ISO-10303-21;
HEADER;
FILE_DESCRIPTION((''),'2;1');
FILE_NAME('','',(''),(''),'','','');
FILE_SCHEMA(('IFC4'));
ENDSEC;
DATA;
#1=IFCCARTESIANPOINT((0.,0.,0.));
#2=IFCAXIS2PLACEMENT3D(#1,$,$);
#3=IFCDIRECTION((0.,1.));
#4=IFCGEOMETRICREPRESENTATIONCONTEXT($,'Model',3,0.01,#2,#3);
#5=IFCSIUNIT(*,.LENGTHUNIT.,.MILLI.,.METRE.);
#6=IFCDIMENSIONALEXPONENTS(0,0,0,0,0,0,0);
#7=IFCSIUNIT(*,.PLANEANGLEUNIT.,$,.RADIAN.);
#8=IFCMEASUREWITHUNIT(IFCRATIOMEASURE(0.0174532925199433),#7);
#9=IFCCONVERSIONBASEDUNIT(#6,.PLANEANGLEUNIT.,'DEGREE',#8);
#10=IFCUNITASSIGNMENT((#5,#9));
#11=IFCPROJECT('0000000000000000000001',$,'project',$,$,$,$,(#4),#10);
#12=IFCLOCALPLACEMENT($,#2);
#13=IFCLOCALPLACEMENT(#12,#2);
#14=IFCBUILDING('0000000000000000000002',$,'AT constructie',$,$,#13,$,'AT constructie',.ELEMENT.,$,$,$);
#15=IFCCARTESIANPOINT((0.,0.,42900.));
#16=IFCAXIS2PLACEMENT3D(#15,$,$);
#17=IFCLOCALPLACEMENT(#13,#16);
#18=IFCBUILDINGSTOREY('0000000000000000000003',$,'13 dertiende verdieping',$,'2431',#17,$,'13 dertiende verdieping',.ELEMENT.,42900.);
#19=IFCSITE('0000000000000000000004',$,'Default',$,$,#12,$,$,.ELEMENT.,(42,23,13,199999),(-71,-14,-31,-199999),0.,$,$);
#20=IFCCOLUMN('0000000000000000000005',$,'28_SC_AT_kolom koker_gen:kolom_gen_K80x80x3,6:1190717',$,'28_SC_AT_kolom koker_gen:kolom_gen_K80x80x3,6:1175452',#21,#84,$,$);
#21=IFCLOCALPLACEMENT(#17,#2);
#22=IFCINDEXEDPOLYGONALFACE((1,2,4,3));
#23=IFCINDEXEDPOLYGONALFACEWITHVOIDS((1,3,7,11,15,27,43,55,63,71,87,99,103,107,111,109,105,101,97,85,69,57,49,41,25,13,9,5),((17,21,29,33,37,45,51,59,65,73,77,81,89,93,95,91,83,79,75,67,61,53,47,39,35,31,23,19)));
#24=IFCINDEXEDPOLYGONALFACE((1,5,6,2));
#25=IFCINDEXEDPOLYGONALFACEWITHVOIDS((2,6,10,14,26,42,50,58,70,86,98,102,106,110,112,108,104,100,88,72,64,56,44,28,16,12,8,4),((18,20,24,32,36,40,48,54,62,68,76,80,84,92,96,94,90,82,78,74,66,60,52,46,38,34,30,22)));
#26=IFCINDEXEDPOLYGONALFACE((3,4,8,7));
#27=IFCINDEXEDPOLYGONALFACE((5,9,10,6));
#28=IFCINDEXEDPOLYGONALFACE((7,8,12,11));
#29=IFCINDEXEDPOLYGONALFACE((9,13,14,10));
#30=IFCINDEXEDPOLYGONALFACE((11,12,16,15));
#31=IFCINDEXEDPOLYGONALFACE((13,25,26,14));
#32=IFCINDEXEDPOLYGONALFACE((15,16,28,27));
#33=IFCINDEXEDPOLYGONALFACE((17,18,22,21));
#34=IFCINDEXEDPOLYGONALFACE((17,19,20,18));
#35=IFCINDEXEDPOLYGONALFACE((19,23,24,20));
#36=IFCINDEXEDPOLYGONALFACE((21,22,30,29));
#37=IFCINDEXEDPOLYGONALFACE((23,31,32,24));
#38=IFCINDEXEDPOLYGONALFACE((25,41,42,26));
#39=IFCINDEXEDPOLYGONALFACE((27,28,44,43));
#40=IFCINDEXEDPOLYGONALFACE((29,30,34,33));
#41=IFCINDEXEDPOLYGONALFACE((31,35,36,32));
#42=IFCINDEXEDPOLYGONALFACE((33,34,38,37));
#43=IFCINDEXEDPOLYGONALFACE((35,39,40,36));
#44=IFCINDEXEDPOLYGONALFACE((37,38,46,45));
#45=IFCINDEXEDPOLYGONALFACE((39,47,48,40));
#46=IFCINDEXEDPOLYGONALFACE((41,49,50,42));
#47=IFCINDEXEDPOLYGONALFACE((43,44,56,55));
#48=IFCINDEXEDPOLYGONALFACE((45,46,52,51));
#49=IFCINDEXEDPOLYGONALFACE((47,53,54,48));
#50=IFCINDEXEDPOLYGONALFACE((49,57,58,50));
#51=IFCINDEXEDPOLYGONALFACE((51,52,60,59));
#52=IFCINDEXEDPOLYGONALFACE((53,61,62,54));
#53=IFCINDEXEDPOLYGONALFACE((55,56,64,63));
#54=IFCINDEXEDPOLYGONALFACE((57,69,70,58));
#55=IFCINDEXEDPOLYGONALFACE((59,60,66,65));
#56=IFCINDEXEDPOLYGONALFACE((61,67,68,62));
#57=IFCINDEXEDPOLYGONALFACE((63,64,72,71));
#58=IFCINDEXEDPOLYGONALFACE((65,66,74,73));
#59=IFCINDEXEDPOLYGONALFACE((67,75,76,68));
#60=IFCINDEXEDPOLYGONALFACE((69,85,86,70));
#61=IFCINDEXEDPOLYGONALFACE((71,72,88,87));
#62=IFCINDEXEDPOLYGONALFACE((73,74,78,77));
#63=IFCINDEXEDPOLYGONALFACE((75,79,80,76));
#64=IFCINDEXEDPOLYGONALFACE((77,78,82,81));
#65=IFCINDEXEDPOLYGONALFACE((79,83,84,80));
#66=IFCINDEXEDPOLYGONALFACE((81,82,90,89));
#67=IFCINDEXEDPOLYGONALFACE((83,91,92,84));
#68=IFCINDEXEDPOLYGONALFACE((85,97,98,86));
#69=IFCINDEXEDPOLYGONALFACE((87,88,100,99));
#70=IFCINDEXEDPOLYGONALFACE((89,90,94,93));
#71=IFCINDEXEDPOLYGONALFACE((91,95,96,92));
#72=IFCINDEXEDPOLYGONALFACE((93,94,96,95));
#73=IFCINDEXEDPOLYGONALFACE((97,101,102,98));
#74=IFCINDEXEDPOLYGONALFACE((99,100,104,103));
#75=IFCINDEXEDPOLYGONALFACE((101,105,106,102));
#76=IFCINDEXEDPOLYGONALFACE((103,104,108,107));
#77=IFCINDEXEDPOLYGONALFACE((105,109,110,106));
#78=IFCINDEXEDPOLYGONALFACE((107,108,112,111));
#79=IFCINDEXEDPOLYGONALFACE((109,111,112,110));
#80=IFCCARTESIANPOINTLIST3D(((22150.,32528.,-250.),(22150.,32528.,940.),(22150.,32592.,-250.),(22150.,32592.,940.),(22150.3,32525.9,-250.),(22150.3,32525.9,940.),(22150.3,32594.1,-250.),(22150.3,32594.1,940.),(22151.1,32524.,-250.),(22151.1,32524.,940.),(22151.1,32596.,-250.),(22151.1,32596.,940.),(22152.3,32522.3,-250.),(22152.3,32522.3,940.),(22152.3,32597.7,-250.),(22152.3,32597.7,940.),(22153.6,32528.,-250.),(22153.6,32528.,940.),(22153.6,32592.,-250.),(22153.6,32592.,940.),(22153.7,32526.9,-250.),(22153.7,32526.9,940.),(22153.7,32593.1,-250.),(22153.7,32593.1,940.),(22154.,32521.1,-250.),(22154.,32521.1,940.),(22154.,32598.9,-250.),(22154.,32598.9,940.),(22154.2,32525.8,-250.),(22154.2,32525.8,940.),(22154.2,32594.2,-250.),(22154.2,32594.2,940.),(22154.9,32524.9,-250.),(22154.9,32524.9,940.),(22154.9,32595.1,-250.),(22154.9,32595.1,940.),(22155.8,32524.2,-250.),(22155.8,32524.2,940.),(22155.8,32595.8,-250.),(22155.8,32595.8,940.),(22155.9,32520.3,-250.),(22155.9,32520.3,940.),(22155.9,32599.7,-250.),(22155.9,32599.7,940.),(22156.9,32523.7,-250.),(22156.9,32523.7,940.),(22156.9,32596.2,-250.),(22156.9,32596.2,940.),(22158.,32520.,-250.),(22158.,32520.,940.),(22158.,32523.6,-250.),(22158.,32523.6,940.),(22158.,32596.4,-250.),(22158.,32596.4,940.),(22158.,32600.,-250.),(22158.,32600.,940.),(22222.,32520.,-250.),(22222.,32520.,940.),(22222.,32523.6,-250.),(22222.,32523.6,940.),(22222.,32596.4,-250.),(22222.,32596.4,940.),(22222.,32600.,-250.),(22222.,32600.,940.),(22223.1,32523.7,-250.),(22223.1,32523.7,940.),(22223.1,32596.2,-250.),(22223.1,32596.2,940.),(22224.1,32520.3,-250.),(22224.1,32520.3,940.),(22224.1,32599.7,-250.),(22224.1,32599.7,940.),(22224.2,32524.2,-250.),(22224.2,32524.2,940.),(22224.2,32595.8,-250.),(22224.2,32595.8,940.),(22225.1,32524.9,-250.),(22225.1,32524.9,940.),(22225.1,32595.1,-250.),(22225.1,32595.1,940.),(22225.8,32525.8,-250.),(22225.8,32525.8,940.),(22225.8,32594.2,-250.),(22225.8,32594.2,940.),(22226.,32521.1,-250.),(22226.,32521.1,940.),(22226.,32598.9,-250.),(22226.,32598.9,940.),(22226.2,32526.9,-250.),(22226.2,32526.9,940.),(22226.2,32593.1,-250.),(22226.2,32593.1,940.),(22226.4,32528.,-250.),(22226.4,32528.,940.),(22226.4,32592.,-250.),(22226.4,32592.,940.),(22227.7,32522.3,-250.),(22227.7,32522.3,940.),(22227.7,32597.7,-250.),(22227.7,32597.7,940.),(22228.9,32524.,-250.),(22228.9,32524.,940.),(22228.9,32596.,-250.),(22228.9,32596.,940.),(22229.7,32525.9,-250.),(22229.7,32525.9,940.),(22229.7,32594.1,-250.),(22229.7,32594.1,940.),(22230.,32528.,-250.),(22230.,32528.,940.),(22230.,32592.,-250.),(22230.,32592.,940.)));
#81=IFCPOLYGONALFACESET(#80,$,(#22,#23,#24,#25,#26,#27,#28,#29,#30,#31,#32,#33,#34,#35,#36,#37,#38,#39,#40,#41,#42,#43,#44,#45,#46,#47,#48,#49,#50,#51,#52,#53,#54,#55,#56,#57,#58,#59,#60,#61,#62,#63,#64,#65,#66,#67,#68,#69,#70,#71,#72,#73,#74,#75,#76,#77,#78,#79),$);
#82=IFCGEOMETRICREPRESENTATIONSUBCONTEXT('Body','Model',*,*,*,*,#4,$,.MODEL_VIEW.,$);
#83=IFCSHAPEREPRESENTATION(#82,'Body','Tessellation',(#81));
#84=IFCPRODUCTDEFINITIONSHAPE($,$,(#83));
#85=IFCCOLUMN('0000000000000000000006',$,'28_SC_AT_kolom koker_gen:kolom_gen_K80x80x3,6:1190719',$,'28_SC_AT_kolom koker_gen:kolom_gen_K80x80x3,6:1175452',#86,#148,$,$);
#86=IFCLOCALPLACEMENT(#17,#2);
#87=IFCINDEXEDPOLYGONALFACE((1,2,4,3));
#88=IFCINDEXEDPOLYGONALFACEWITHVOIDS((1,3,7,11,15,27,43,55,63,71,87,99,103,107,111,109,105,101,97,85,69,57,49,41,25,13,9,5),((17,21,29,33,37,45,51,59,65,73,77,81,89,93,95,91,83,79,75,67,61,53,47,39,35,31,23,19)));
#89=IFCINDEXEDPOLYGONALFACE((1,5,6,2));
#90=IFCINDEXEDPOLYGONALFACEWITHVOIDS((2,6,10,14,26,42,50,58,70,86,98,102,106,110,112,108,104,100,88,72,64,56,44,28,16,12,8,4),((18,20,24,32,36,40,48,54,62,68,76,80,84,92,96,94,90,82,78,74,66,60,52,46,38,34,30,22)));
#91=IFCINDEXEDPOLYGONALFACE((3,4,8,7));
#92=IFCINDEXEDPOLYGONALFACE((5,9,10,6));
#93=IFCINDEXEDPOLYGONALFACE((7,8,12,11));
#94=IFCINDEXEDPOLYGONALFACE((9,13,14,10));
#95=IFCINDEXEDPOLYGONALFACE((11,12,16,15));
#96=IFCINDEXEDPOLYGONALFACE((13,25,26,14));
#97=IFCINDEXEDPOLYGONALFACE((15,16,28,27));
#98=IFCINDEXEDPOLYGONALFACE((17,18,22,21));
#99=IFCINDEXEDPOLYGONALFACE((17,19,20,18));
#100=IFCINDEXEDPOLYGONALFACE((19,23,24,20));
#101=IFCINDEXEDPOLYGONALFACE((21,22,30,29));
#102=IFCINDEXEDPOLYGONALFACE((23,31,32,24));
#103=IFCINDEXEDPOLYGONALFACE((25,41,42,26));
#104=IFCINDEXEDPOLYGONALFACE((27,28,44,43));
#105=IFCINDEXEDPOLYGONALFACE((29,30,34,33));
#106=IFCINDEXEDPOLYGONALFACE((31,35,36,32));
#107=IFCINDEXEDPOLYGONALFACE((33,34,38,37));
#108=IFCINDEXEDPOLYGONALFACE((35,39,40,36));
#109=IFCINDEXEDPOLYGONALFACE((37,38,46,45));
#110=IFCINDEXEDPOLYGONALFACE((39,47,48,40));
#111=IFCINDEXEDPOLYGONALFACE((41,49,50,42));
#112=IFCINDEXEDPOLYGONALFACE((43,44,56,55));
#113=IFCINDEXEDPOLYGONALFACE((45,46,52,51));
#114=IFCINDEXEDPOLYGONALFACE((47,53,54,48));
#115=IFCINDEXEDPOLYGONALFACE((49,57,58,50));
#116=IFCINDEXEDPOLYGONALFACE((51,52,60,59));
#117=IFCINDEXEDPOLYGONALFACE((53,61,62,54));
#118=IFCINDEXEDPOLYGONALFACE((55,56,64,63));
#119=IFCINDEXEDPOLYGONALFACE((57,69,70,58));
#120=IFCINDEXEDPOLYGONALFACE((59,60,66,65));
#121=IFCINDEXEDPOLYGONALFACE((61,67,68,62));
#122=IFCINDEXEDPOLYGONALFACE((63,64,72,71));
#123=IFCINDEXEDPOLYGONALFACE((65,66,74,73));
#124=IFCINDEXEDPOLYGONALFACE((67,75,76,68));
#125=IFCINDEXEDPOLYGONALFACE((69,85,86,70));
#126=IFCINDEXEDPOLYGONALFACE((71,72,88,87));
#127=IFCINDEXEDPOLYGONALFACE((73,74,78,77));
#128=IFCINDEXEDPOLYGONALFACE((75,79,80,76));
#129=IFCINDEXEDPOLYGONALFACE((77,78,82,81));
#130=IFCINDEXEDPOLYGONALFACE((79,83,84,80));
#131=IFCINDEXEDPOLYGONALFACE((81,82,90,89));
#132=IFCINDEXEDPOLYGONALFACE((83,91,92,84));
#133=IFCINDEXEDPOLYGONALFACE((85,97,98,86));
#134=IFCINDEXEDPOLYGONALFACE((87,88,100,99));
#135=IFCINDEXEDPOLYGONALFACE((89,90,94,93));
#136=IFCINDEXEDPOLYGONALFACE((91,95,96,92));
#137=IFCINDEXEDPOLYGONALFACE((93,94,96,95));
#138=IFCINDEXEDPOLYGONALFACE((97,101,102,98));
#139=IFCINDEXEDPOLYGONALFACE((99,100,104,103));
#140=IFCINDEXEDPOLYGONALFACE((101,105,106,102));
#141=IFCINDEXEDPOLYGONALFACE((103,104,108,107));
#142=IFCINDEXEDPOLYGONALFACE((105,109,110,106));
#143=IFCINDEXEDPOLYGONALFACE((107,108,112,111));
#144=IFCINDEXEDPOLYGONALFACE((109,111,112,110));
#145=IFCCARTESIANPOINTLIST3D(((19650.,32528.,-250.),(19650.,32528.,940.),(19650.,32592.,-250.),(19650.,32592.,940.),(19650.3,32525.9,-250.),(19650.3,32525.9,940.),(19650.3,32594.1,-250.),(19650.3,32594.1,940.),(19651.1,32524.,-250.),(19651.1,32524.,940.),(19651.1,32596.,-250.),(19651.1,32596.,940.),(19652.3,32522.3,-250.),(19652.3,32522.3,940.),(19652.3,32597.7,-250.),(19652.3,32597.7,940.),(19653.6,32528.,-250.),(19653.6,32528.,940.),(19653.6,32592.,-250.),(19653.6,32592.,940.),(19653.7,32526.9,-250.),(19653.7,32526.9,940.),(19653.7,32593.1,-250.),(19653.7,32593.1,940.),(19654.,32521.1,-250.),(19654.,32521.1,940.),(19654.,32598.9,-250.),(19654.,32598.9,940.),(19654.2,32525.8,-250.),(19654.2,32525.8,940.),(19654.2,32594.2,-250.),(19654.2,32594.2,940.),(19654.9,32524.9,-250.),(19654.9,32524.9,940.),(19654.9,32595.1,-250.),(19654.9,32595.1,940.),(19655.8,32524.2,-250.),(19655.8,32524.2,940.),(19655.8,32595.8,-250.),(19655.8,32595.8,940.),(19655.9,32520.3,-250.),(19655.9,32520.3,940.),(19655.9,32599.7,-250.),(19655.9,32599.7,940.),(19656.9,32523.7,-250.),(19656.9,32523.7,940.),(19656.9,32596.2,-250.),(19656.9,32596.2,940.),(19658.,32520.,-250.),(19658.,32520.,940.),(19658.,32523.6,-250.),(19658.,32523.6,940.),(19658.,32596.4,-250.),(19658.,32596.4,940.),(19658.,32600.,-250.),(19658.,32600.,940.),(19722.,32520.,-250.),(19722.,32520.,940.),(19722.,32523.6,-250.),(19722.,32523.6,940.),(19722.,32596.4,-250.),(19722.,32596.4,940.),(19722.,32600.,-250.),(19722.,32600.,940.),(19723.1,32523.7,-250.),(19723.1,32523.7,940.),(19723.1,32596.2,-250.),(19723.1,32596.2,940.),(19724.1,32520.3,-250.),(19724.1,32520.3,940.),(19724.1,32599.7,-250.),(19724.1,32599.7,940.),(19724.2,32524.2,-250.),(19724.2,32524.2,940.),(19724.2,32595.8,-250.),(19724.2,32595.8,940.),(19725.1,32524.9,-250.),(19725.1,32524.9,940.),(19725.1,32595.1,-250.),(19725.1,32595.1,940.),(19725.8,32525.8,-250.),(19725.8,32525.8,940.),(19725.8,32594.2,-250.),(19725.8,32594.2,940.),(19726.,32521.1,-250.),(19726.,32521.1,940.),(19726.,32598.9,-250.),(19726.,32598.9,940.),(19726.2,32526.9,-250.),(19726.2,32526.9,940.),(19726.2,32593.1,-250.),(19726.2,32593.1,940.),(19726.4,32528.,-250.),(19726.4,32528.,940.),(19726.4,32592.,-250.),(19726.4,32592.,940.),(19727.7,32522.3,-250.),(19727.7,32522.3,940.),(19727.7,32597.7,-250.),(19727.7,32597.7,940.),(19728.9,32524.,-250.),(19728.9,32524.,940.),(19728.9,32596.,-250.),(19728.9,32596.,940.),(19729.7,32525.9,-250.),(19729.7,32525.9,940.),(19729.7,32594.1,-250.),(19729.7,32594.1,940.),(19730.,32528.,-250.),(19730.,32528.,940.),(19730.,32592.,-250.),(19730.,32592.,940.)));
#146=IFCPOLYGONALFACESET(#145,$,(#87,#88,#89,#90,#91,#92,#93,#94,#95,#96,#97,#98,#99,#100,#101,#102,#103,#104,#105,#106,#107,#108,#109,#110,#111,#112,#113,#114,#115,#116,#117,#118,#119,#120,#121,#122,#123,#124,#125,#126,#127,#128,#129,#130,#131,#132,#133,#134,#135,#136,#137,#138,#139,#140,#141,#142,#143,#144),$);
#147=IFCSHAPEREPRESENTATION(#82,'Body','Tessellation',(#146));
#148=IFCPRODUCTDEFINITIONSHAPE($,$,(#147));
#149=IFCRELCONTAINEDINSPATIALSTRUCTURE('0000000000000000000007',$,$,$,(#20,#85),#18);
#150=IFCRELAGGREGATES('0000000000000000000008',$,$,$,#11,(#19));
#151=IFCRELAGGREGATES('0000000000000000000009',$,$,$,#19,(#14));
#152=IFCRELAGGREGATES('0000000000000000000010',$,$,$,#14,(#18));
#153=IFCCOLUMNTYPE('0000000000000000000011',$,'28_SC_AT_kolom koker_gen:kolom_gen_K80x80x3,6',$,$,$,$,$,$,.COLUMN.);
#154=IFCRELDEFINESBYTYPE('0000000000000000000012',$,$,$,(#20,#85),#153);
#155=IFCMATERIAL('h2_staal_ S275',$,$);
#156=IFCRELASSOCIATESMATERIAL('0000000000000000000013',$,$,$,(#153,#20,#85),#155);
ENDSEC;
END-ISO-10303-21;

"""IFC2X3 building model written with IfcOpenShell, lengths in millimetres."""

from ifc_helpers import new_model, entity, si_unit, converted_unit, direction, frame, frame_2d, origin, place, context, subcontext, project, spatial, polyline, circle_curve, parameter, trimmed, segment, composite_curve, outline, extrude, source, transform, mapped, material, type_object, type_shapes, element, save


model = new_model("IFC2X3")

# Units and contexts
model_context = context("Model", 3, precision=0.01, world=origin(), true_north=direction((0.0, 1.0)))
body_context = subcontext(model_context, "Body", "Model", "MODEL_VIEW")
ifc_project = project(units=[si_unit("LENGTHUNIT", "METRE", prefix="MILLI"), converted_unit("PLANEANGLEUNIT", "DEGREE", entity("IfcRatioMeasure", 0.0174532925199433), si_unit("PLANEANGLEUNIT", "RADIAN"), dimensions=[0, 0, 0, 0, 0, 0, 0])], contexts=[model_context])

# Site, building, storey
site_placement = place(None, origin())
site = spatial("IfcSite", under=ifc_project, at=site_placement, Name="Default", CompositionType="ELEMENT", RefLatitude=(42, 23, 13, 199999), RefLongitude=(-71, -14, -31, -199999), RefElevation=0.0)
building_placement = place(site_placement, origin())
building = spatial("IfcBuilding", under=site, at=building_placement, Name="AT constructie", LongName="AT constructie", CompositionType="ELEMENT")
storey_placement = place(building_placement, frame((0.0, 0.0, 42900.0)))
storey = spatial("IfcBuildingStorey", under=building, at=storey_placement, Name="13 dertiende verdieping", ObjectType="2431", LongName="13 dertiende verdieping", CompositionType="ELEMENT", Elevation=42900.0)

# Columns
ifc_material = material(Name="h2_staal_ S275")
column_type_1 = type_object("IfcColumnType", Name="28_SC_AT_kolom koker_gen:kolom_gen_K80x80x3,6", PredefinedType="COLUMN", material=ifc_material)
shared_shape_1 = source(origin(), body_context, "Body", "SweptSolid", [
    extrude(outline(composite_curve([segment(trimmed(circle_curve(frame_2d((32.0, 32.0), x_axis=(1.0, 0.0)), 8.0), [parameter(360.0)], [parameter(90.0)], True, "PARAMETER"), True, "CONTINUOUS"), segment(polyline([(32.0, 40.0), (-32.0, 40.0)]), True, "CONTINUOUS"), segment(trimmed(circle_curve(frame_2d((-32.0, 32.0), x_axis=(1.0, 0.0)), 8.0), [parameter(90.0)], [parameter(180.0)], True, "PARAMETER"), True, "CONTINUOUS"), segment(polyline([(-40.0, 32.0), (-40.0, -32.0)]), True, "CONTINUOUS"), segment(trimmed(circle_curve(frame_2d((-32.0, -32.0), x_axis=(1.0, 0.0)), 8.0), [parameter(180.0)], [parameter(270.0)], True, "PARAMETER"), True, "CONTINUOUS"), segment(polyline([(-32.0, -40.0), (32.0, -40.0)]), True, "CONTINUOUS"), segment(trimmed(circle_curve(frame_2d((32.0, -32.0), x_axis=(1.0, 0.0)), 8.0), [parameter(270.0)], [parameter(0.0)], True, "PARAMETER"), True, "CONTINUOUS"), segment(polyline([(40.0, -32.0), (40.0, 32.0)]), True, "CONTINUOUS")], self_intersect=False), holes=[composite_curve([segment(polyline([(-32.0, 36.4), (32.0, 36.4)]), True, "CONTINUOUS"), segment(trimmed(circle_curve(frame_2d((32.0, 32.0), x_axis=(1.0, 0.0)), 4.4), [parameter(360.0)], [parameter(90.0)], True, "PARAMETER"), False, "CONTINUOUS"), segment(polyline([(36.4, 32.0), (36.4, -32.0)]), True, "CONTINUOUS"), segment(trimmed(circle_curve(frame_2d((32.0, -32.0), x_axis=(1.0, 0.0)), 4.4), [parameter(270.0)], [parameter(360.0)], True, "PARAMETER"), False, "CONTINUOUS"), segment(polyline([(32.0, -36.4), (-32.0, -36.4)]), True, "CONTINUOUS"), segment(trimmed(circle_curve(frame_2d((-32.0, -32.0), x_axis=(1.0, 0.0)), 4.4), [parameter(180.0)], [parameter(270.0)], True, "PARAMETER"), False, "CONTINUOUS"), segment(polyline([(-36.4, -32.0), (-36.4, 32.0)]), True, "CONTINUOUS"), segment(trimmed(circle_curve(frame_2d((-32.0, 32.0), x_axis=(1.0, 0.0)), 4.4), [parameter(90.0)], [parameter(180.0)], True, "PARAMETER"), False, "CONTINUOUS")], self_intersect=False)]), frame((0.0, 0.0, 42650.0), z_axis=(0.0, 0.0, 1.0), x_axis=(-1.0, 0.0, 0.0)), (0.0, 0.0, 1.0), 1190.0),
])
type_shapes(column_type_1, [shared_shape_1])
for number, where, name in (
    (1, (22190.0, 32560.0, -42900.0), "28_SC_AT_kolom koker_gen:kolom_gen_K80x80x3,6:1190717"),
    (2, (19690.0, 32560.0, -42900.0), "28_SC_AT_kolom koker_gen:kolom_gen_K80x80x3,6:1190719"),
):
    element("IfcColumn", number, at=place(storey_placement, frame(where)), inside=storey, type_object=column_type_1, material=ifc_material, Name=name, ObjectType="28_SC_AT_kolom koker_gen:kolom_gen_K80x80x3,6:1175452", context=body_context, shape_type="MappedRepresentation", body=[
        mapped(shared_shape_1, transform((0.0, 0.0, 0.0), scale=1.0)),
    ])

save(model, "model.ifc")
